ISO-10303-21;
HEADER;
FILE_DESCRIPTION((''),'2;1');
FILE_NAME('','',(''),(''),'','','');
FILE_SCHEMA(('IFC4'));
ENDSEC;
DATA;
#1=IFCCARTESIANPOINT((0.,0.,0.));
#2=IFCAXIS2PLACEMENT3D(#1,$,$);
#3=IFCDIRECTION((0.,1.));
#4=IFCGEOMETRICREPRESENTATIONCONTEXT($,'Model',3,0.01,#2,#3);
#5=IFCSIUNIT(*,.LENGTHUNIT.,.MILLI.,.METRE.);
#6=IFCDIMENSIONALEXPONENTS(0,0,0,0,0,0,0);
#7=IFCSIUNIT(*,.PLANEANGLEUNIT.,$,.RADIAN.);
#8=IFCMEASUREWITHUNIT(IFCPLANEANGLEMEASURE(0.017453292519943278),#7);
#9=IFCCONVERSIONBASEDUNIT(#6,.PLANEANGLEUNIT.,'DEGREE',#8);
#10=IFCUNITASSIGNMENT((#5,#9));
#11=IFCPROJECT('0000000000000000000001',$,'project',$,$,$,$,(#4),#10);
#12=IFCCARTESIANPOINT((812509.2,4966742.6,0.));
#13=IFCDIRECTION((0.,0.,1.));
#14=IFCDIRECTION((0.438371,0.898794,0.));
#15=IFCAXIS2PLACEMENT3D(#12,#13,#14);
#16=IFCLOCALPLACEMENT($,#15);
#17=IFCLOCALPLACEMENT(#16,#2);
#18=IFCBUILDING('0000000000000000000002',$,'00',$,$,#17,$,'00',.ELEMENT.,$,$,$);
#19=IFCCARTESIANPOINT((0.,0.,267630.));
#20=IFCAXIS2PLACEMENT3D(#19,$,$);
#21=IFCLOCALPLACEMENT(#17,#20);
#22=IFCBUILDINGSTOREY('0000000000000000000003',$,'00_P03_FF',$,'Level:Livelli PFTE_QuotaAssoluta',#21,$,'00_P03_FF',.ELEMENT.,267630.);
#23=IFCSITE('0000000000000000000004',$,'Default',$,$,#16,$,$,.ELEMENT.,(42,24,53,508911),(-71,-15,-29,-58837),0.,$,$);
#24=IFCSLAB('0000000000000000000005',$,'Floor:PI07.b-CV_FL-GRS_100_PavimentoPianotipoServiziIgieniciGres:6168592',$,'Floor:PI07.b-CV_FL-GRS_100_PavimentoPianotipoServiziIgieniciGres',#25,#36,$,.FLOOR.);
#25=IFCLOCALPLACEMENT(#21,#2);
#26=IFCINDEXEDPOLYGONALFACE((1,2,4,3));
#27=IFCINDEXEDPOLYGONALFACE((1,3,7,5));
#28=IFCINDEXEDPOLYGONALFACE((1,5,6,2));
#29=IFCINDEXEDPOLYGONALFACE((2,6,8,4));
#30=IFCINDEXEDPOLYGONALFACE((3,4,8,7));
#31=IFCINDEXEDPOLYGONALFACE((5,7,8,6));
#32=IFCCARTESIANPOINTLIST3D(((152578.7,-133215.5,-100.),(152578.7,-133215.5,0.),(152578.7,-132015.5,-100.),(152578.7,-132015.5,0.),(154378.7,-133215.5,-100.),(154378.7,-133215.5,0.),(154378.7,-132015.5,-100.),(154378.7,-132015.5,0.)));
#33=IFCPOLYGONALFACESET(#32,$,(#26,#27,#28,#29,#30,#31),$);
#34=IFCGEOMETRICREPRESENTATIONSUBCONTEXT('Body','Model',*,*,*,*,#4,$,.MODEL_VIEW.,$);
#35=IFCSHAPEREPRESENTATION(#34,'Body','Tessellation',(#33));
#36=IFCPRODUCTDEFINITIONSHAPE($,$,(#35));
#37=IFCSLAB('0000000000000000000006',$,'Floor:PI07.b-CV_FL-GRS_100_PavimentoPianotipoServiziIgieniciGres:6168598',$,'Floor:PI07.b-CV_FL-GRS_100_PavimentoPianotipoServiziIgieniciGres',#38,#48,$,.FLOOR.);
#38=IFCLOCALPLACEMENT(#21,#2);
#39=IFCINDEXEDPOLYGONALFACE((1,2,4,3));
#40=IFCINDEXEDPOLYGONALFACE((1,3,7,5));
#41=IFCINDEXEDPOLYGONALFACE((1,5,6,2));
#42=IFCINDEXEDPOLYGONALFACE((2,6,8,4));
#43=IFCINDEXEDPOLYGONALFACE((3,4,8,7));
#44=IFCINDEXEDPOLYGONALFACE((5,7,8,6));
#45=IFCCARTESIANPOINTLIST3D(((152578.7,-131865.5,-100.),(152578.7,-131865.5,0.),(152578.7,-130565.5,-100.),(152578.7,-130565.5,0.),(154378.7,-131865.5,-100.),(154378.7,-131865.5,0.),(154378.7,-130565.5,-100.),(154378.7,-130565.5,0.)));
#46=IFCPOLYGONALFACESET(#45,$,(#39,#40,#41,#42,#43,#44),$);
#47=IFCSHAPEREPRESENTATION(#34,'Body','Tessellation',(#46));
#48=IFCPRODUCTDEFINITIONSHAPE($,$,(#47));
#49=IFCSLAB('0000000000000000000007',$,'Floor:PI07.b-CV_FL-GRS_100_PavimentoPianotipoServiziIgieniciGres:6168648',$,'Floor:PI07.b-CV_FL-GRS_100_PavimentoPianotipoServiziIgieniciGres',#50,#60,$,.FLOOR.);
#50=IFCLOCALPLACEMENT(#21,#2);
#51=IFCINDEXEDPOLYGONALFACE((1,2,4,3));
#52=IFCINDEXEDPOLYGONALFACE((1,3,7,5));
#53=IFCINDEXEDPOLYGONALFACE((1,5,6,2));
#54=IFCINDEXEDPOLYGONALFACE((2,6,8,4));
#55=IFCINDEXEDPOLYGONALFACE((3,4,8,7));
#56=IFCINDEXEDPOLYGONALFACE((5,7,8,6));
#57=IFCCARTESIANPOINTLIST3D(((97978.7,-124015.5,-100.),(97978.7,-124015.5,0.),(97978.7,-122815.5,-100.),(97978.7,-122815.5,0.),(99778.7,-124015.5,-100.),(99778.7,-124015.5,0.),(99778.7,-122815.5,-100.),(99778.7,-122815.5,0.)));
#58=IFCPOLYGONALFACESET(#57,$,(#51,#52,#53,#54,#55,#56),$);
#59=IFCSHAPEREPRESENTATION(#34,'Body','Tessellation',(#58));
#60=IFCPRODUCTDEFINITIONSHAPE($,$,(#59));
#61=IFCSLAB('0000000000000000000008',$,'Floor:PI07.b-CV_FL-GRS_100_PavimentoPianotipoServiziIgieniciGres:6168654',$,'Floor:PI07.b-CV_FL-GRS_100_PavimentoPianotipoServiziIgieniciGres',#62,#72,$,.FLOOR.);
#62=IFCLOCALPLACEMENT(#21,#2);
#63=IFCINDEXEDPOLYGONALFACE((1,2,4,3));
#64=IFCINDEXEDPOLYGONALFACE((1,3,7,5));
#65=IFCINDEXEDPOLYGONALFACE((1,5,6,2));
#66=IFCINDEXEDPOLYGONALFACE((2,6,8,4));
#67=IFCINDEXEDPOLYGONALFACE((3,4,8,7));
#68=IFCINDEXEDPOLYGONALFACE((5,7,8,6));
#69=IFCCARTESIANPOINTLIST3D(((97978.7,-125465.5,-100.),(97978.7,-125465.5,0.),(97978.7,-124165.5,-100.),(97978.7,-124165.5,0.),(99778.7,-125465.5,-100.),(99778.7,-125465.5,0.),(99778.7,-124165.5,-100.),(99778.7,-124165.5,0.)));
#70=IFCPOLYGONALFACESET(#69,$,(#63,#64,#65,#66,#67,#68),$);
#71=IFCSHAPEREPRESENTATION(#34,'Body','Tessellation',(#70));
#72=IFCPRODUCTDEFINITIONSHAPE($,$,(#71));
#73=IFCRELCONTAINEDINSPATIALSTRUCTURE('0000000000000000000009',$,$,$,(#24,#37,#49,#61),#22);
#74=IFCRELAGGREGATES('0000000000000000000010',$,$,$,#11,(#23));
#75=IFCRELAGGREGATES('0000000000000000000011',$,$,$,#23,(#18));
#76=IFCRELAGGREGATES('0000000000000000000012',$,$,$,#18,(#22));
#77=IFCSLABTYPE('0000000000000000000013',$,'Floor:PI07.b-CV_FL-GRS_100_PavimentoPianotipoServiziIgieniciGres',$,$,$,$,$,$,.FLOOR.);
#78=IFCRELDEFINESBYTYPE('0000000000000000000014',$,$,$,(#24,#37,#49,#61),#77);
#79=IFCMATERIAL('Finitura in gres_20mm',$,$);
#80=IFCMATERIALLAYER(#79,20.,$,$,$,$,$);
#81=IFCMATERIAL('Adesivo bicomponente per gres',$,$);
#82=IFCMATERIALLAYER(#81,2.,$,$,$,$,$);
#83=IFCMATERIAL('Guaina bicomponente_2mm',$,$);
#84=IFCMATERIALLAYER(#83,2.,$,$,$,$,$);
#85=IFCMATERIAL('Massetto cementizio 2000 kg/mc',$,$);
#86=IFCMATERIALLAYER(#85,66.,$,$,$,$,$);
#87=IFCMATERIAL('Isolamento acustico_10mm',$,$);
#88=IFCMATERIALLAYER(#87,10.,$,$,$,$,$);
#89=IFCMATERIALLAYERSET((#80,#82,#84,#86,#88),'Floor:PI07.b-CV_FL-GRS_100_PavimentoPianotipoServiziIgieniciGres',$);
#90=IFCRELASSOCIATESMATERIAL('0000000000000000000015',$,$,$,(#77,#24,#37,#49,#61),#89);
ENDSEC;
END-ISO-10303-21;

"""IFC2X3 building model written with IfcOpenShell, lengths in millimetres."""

from ifc_helpers import new_model, entity, si_unit, converted_unit, direction, frame, frame_2d, origin, origin_2d_with_axis, place, context, subcontext, project, spatial, rectangle, extrude, material, layer, layer_set, layer_usage, type_object, element, save


model = new_model("IFC2X3")

# Units and contexts
model_context = context("Model", 3, precision=0.01, world=origin(), true_north=direction((0.0, 1.0)))
body_context = subcontext(model_context, "Body", "Model", "MODEL_VIEW")
ifc_project = project(units=[si_unit("LENGTHUNIT", "METRE", prefix="MILLI"), converted_unit("PLANEANGLEUNIT", "DEGREE", entity("IfcPlaneAngleMeasure", 0.017453292519943278), si_unit("PLANEANGLEUNIT", "RADIAN"), dimensions=[0, 0, 0, 0, 0, 0, 0])], contexts=[model_context])

# Site, building, storey
site_placement = place(None, frame((812509.2, 4966742.6, 0.0), z_axis=(0.0, 0.0, 1.0), x_axis=(0.438371, 0.898794, 0.0)))
site = spatial("IfcSite", under=ifc_project, at=site_placement, Name="Default", CompositionType="ELEMENT", RefLatitude=(42, 24, 53, 508911), RefLongitude=(-71, -15, -29, -58837), RefElevation=0.0)
building_placement = place(site_placement, origin())
building = spatial("IfcBuilding", under=site, at=building_placement, Name="00", LongName="00", CompositionType="ELEMENT")
storey_placement = place(building_placement, frame((0.0, 0.0, 267630.0)))
storey = spatial("IfcBuildingStorey", under=building, at=storey_placement, Name="00_P03_FF", ObjectType="Level:Livelli PFTE_QuotaAssoluta", LongName="00_P03_FF", CompositionType="ELEMENT", Elevation=267630.0)

# Slabs
ifc_material_1 = material(Name="Finitura in gres_20mm")
ifc_layer_1 = layer(ifc_material_1, 20.0)
ifc_material_2 = material(Name="Adesivo bicomponente per gres")
ifc_layer_2 = layer(ifc_material_2, 2.0)
ifc_material_3 = material(Name="Guaina bicomponente_2mm")
ifc_layer_3 = layer(ifc_material_3, 2.0)
ifc_material_4 = material(Name="Massetto cementizio 2000 kg/mc")
ifc_layer_4 = layer(ifc_material_4, 66.0)
ifc_material_5 = material(Name="Isolamento acustico_10mm")
ifc_layer_5 = layer(ifc_material_5, 10.0)
ifc_layer_set = layer_set([ifc_layer_1, ifc_layer_2, ifc_layer_3, ifc_layer_4, ifc_layer_5], Name="Floor:PI07.b-CV_FL-GRS_100_PavimentoPianotipoServiziIgieniciGres")
slab_type = type_object("IfcSlabType", Name="Floor:PI07.b-CV_FL-GRS_100_PavimentoPianotipoServiziIgieniciGres", PredefinedType="FLOOR", material=ifc_layer_set)
ifc_layer_usage_1 = layer_usage(ifc_layer_set, "AXIS3", "POSITIVE", 0.0)
slab_1_placement = place(storey_placement, origin())
element("IfcSlab", 1, at=slab_1_placement, inside=storey, type_object=slab_type, material=ifc_layer_usage_1, Name="Floor:PI07.b-CV_FL-GRS_100_PavimentoPianotipoServiziIgieniciGres:6168592", ObjectType="Floor:PI07.b-CV_FL-GRS_100_PavimentoPianotipoServiziIgieniciGres", PredefinedType="FLOOR", context=body_context, shape_type="SweptSolid", body=[
    extrude(rectangle(XDim=1200.0, YDim=1800.0, at=origin_2d_with_axis()), frame((153478.7, -132615.5, 0.0), z_axis=(0.0, 0.0, -1.0), x_axis=(0.0, 1.0, 0.0)), (0.0, 0.0, 1.0), 100.0),
])
ifc_layer_usage_2 = layer_usage(ifc_layer_set, "AXIS3", "POSITIVE", 0.0)
slab_2_placement = place(storey_placement, origin())
element("IfcSlab", 2, at=slab_2_placement, inside=storey, type_object=slab_type, material=ifc_layer_usage_2, Name="Floor:PI07.b-CV_FL-GRS_100_PavimentoPianotipoServiziIgieniciGres:6168598", ObjectType="Floor:PI07.b-CV_FL-GRS_100_PavimentoPianotipoServiziIgieniciGres", PredefinedType="FLOOR", context=body_context, shape_type="SweptSolid", body=[
    extrude(rectangle(XDim=1300.0, YDim=1800.0, at=frame_2d((0.0, 0.0), x_axis=(1.0, 0.0))), frame((153478.7, -131215.5, 0.0), z_axis=(0.0, 0.0, -1.0), x_axis=(0.0, 1.0, 0.0)), (0.0, 0.0, 1.0), 100.0),
])
ifc_layer_usage_3 = layer_usage(ifc_layer_set, "AXIS3", "POSITIVE", 0.0)
slab_3_placement = place(storey_placement, origin())
element("IfcSlab", 3, at=slab_3_placement, inside=storey, type_object=slab_type, material=ifc_layer_usage_3, Name="Floor:PI07.b-CV_FL-GRS_100_PavimentoPianotipoServiziIgieniciGres:6168648", ObjectType="Floor:PI07.b-CV_FL-GRS_100_PavimentoPianotipoServiziIgieniciGres", PredefinedType="FLOOR", context=body_context, shape_type="SweptSolid", body=[
    extrude(rectangle(XDim=1200.0, YDim=1800.0, at=origin_2d_with_axis()), frame((98878.7, -123415.5, 0.0), z_axis=(0.0, 0.0, -1.0), x_axis=(0.0, 1.0, 0.0)), (0.0, 0.0, 1.0), 100.0),
])
ifc_layer_usage_4 = layer_usage(ifc_layer_set, "AXIS3", "POSITIVE", 0.0)
slab_4_placement = place(storey_placement, origin())
element("IfcSlab", 4, at=slab_4_placement, inside=storey, type_object=slab_type, material=ifc_layer_usage_4, Name="Floor:PI07.b-CV_FL-GRS_100_PavimentoPianotipoServiziIgieniciGres:6168654", ObjectType="Floor:PI07.b-CV_FL-GRS_100_PavimentoPianotipoServiziIgieniciGres", PredefinedType="FLOOR", context=body_context, shape_type="SweptSolid", body=[
    extrude(rectangle(XDim=1300.0, YDim=1800.0, at=frame_2d((0.0, 0.0), x_axis=(1.0, 0.0))), frame((98878.7, -124815.5, 0.0), z_axis=(0.0, 0.0, -1.0), x_axis=(0.0, 1.0, 0.0)), (0.0, 0.0, 1.0), 100.0),
])

save(model, "model.ifc")
